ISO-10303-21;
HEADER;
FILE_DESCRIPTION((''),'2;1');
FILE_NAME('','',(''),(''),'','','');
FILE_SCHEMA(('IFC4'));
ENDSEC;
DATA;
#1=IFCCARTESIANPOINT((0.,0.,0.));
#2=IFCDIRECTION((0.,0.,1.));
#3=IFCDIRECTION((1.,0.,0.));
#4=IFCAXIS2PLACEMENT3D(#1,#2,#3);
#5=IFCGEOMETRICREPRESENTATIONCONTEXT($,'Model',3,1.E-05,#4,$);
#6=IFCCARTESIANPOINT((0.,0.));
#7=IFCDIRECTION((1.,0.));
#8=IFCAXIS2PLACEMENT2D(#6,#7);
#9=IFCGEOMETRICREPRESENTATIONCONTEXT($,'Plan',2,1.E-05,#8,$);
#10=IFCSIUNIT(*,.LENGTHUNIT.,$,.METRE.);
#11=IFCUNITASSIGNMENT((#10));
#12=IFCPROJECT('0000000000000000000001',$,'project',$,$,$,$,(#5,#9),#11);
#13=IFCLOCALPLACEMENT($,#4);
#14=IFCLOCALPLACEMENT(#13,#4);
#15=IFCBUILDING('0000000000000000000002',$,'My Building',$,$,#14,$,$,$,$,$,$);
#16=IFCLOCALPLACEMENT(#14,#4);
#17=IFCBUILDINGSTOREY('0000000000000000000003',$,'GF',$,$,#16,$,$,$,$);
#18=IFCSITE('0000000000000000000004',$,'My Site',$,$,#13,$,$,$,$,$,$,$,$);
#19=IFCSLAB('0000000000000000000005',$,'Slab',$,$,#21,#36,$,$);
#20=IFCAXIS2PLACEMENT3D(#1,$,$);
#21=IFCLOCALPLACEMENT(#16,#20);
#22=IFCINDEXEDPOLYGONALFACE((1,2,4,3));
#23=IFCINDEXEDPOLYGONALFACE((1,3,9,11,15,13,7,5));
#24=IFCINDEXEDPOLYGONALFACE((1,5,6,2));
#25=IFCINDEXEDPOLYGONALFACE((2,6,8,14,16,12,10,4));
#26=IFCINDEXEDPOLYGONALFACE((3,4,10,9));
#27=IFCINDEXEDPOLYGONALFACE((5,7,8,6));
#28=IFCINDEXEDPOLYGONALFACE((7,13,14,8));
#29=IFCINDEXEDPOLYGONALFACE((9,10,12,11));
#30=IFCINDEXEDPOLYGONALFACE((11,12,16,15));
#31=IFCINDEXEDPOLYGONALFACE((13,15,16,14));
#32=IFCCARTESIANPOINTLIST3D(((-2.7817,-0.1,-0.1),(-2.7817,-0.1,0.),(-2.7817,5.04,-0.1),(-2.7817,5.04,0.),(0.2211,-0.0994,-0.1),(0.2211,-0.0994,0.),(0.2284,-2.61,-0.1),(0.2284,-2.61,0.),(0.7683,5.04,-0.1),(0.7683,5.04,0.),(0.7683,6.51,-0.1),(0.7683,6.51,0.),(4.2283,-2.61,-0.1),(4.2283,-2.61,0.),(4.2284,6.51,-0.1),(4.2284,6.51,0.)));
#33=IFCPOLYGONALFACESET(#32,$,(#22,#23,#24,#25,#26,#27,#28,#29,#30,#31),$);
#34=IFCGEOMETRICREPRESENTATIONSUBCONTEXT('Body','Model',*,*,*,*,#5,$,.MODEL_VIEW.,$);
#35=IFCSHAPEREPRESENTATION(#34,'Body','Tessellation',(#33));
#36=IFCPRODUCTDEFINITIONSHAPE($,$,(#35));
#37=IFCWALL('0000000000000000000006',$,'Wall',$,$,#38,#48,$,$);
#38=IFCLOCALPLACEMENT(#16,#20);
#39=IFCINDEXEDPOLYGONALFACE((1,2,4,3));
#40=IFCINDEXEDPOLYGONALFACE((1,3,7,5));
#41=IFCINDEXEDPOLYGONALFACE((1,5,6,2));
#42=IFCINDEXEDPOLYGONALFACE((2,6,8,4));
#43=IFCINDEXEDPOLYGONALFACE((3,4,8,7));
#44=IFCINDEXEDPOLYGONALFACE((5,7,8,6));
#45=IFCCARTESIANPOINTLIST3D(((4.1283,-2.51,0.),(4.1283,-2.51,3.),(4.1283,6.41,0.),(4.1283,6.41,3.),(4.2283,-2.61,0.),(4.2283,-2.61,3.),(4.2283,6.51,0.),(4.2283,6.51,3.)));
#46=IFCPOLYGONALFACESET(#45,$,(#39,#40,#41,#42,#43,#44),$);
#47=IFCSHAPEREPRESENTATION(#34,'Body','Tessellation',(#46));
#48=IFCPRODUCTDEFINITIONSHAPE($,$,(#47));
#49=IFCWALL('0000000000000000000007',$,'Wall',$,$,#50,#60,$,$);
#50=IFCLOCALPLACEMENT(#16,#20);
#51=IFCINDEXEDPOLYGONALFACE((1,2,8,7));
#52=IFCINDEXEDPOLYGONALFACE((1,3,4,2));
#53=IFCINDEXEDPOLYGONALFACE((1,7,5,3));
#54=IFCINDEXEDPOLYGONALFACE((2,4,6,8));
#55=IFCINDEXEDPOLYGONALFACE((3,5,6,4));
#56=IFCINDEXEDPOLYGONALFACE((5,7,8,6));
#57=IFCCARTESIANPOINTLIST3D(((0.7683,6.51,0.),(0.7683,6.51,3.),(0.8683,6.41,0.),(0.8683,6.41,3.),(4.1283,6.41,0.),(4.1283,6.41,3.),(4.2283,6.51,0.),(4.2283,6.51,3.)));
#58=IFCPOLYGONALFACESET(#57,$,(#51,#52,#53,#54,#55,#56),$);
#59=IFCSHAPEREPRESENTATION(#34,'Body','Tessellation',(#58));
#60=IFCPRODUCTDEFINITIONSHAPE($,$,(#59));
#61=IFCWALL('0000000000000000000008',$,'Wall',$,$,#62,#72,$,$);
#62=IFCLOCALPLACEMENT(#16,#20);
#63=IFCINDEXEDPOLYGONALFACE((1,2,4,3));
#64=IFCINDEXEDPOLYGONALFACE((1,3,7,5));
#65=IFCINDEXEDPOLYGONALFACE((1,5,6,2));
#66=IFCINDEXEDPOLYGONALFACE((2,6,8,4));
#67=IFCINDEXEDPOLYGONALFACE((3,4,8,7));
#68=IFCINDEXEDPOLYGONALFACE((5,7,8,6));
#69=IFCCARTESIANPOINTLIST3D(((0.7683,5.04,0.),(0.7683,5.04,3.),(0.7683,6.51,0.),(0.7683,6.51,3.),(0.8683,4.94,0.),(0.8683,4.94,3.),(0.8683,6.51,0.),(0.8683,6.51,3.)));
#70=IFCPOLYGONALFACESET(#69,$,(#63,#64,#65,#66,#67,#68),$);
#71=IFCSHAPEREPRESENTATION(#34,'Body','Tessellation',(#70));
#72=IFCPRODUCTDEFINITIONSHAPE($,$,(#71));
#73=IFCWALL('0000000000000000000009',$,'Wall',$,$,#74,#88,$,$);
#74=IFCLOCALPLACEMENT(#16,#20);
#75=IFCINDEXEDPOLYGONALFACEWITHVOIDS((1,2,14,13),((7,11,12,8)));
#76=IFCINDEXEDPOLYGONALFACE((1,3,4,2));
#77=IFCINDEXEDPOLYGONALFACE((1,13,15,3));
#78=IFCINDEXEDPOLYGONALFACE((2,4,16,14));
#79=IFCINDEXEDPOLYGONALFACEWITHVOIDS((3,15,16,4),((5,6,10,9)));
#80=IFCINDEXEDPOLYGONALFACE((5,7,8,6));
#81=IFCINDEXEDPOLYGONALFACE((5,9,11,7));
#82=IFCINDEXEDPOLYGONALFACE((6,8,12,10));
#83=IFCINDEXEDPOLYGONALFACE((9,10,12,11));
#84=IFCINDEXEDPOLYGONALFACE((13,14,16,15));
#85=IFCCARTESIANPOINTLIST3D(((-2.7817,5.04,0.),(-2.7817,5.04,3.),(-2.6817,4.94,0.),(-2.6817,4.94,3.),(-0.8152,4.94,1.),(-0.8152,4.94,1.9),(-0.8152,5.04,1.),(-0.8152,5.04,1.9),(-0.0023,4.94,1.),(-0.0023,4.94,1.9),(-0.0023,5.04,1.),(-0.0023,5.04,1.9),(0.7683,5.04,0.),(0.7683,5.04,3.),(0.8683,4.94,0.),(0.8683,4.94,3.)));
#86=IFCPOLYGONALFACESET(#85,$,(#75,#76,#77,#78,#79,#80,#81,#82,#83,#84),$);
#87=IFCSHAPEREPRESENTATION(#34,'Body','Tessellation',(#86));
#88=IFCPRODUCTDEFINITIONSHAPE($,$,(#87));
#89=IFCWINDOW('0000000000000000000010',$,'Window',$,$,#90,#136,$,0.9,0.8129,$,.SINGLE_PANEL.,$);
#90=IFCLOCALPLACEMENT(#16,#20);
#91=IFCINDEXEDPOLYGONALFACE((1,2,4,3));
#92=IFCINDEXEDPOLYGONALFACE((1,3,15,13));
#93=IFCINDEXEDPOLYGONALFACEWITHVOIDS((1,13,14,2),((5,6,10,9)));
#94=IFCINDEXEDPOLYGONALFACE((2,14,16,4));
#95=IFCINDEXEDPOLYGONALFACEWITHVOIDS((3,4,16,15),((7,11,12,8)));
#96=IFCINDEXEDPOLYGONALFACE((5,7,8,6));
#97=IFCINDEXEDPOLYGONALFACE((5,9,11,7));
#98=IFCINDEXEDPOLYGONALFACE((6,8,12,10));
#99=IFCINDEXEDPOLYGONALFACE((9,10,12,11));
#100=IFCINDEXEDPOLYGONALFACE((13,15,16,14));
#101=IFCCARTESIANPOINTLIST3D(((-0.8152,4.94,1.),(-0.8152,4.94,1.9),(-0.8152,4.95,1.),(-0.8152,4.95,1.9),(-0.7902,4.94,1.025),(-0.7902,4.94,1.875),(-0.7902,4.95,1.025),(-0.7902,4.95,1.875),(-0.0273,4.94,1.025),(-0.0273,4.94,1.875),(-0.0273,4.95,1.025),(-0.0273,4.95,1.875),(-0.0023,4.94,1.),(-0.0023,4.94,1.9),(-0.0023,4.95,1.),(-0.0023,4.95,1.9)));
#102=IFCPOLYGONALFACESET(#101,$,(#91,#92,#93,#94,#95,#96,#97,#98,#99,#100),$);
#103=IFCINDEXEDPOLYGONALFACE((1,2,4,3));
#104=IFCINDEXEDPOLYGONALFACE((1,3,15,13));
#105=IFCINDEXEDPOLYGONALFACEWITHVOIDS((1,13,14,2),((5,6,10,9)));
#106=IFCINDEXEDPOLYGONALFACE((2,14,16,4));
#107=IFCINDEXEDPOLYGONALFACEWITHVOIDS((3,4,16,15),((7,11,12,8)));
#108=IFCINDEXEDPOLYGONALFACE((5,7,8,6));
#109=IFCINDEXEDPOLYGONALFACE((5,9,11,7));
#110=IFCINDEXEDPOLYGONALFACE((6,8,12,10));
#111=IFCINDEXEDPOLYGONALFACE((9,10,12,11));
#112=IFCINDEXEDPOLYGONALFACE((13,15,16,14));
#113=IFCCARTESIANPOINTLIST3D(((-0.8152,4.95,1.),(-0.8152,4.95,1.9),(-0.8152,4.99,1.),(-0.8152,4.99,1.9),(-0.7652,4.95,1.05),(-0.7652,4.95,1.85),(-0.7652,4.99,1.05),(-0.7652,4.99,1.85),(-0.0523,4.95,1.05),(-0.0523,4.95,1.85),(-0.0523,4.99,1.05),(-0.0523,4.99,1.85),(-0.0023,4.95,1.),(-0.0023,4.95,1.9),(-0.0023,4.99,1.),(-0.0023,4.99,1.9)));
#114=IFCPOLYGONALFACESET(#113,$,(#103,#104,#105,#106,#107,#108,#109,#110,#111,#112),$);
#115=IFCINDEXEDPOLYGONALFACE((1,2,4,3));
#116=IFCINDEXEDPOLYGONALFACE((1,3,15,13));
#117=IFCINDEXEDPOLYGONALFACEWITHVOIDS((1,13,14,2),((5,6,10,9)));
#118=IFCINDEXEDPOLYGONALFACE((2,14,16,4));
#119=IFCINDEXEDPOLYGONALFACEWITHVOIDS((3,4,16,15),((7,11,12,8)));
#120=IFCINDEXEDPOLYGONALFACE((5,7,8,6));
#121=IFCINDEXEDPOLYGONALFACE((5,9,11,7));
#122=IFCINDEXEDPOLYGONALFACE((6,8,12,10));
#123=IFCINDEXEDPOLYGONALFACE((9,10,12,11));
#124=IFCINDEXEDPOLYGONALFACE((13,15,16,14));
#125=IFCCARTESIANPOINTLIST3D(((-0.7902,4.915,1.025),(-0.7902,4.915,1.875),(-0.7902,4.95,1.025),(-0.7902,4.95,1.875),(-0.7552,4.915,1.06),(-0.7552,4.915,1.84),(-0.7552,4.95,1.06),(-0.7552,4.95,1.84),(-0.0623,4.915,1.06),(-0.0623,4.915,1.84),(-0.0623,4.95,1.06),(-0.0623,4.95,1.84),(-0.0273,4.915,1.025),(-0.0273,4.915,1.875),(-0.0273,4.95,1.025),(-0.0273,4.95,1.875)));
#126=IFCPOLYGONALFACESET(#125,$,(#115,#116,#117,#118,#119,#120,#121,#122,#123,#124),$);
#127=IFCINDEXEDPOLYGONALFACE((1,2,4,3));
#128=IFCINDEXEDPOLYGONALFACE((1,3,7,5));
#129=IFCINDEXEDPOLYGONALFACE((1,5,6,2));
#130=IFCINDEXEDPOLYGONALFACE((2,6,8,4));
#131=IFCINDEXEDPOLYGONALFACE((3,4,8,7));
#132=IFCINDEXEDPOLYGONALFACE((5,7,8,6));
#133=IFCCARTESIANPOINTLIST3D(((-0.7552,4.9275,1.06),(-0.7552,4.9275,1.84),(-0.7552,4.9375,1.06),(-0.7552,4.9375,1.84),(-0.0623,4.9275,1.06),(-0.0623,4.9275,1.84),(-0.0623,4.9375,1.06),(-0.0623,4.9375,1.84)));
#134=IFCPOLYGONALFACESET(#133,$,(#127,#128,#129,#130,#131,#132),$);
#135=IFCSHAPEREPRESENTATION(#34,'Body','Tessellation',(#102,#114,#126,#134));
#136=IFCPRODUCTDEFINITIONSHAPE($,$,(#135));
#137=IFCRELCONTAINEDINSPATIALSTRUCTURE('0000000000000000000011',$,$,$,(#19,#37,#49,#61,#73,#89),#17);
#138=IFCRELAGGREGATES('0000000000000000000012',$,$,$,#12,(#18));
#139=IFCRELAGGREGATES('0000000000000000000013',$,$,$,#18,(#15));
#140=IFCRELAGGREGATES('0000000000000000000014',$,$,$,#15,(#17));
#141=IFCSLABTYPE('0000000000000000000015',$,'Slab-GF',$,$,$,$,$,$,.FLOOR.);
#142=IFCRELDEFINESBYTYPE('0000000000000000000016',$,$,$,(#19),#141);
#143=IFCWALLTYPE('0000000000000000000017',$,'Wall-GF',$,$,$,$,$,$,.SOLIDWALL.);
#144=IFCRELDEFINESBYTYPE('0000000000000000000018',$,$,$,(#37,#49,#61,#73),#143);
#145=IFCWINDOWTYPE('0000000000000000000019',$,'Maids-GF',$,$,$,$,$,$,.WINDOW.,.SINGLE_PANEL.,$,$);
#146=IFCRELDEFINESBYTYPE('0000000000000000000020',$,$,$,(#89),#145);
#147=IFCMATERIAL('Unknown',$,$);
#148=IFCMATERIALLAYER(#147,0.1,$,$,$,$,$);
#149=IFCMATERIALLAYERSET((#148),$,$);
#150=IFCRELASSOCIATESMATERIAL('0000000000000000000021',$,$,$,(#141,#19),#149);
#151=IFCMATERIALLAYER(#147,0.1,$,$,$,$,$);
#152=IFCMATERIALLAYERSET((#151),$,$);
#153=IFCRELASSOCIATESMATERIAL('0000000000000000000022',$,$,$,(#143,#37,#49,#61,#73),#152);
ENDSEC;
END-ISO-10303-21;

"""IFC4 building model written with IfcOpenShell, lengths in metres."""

from ifc_helpers import new_model, entity, si_unit, frame, origin_with_axes, origin_2d_with_axis, place, context, subcontext, project, spatial, line, indexed_curve, outline, extrude, shape, source, transform, mapped, material, layer, layer_set, layer_usage, type_object, type_shapes, element, fill, save


model = new_model("IFC4")

# Units and contexts
model_context = context("Model", 3, precision=1e-05, world=origin_with_axes())
plan_context = context("Plan", 2, precision=1e-05, world=origin_2d_with_axis())
body_context_1 = subcontext(model_context, "Body", "Model", "MODEL_VIEW")
body_context_2 = subcontext(plan_context, "Body", "Plan", "PLAN_VIEW")
ifc_project = project(units=[si_unit("LENGTHUNIT", "METRE")], contexts=[model_context, plan_context])

# Site, building, storey
site_placement = place(None, origin_with_axes())
site = spatial("IfcSite", under=ifc_project, at=site_placement, Name="My Site")
building_placement = place(site_placement, origin_with_axes())
building = spatial("IfcBuilding", under=site, at=building_placement, Name="My Building")
storey_placement = place(building_placement, origin_with_axes())
storey = spatial("IfcBuildingStorey", under=building, at=storey_placement, Name="GF")

# Slab
ifc_material_1 = material(Name="Unknown")
ifc_layer_1 = layer(ifc_material_1, 0.1)
ifc_layer_set_1 = layer_set([ifc_layer_1])
ifc_layer_usage_1 = layer_usage(ifc_layer_set_1, "AXIS3", "POSITIVE", -0.1)
slab_type_1 = type_object("IfcSlabType", Name="Slab-GF", PredefinedType="FLOOR", material=ifc_layer_set_1)
slab_1_placement = place(storey_placement, frame((4.2283, -2.61, 0.0), z_axis=(0.0, 0.0, 1.0), x_axis=(1.0, 0.0, 0.0)))
element("IfcSlab", 1, at=slab_1_placement, inside=storey, type_object=slab_type_1, material=ifc_layer_usage_1, Name="Slab", context=body_context_1, shape_type="SweptSolid", body=[
    extrude(outline(indexed_curve([(0.0, 0.0), (0.0, 9.12), (-3.46, 9.12), (-3.46, 7.65), (-7.01, 7.65), (-7.01, 2.51), (-4.0073, 2.5106), (-4.0, 0.0), (0.0, 0.0)])), frame((0.0, 0.0, -0.1), z_axis=(0.0, 0.0, 1.0), x_axis=(1.0, 0.0, 0.0)), (0.0, 0.0, 1.0), 0.1),
])

# Shared definitions
ifc_layer_2 = layer(ifc_material_1, 0.1)
ifc_layer_set_2 = layer_set([ifc_layer_2])
wall_type = type_object("IfcWallType", Name="Wall-GF", PredefinedType="SOLIDWALL", material=ifc_layer_set_2)

# Walls
ifc_layer_usage_2 = layer_usage(ifc_layer_set_2, "AXIS2", "POSITIVE", 0.0)
wall_1_placement = place(storey_placement, frame((4.2283, -2.61, 0.0), z_axis=(0.0, 0.0, 1.0), x_axis=(0.0, 1.0, 0.0)))
element("IfcWall", 2, at=wall_1_placement, inside=storey, type_object=wall_type, material=ifc_layer_usage_2, Name="Wall", context=body_context_1, shape_type="SweptSolid", body=[
    extrude(outline(indexed_curve([(0.0, 0.0), (0.1, 0.1), (9.02, 0.1), (9.12, 0.0)], segments=[line(1, 2, 3, 4, 1)])), origin_with_axes(), (0.0, 0.0, 1.0), 3.0),
])
ifc_layer_usage_3 = layer_usage(ifc_layer_set_2, "AXIS2", "POSITIVE", 0.0)
wall_2_placement = place(storey_placement, frame((4.2283, 6.51, 0.0), z_axis=(0.0, 0.0, 1.0), x_axis=(-1.0, 0.0, 0.0)))
element("IfcWall", 3, at=wall_2_placement, inside=storey, type_object=wall_type, material=ifc_layer_usage_3, Name="Wall", context=body_context_1, shape_type="SweptSolid", body=[
    extrude(outline(indexed_curve([(0.0, 0.0), (0.1, 0.1), (3.36, 0.1), (3.46, 0.0)], segments=[line(1, 2, 3, 4, 1)])), origin_with_axes(), (0.0, 0.0, 1.0), 3.0),
])
ifc_layer_usage_4 = layer_usage(ifc_layer_set_2, "AXIS2", "POSITIVE", 0.0)
wall_3_placement = place(storey_placement, frame((0.7683, 6.51, 0.0), z_axis=(0.0, 0.0, 1.0), x_axis=(0.0, -1.0, 0.0)))
element("IfcWall", 4, at=wall_3_placement, inside=storey, type_object=wall_type, material=ifc_layer_usage_4, Name="Wall", context=body_context_1, shape_type="SweptSolid", body=[
    extrude(outline(indexed_curve([(0.0, 0.0), (0.0, 0.1), (1.57, 0.1), (1.47, 0.0)], segments=[line(1, 2, 3, 4, 1)])), origin_with_axes(), (0.0, 0.0, 1.0), 3.0),
])

# Wall, opening, window
ifc_layer_usage_5 = layer_usage(ifc_layer_set_2, "AXIS2", "POSITIVE", 0.0)
wall_4_placement = place(storey_placement, frame((0.7683, 5.04, 0.0), z_axis=(0.0, 0.0, 1.0), x_axis=(-1.0, 0.0, 0.0)))
wall_4 = element("IfcWall", 5, at=wall_4_placement, inside=storey, type_object=wall_type, material=ifc_layer_usage_5, Name="Wall", context=body_context_1, shape_type="SweptSolid", body=[
    extrude(outline(indexed_curve([(0.0, 0.0), (-0.1, 0.1), (3.45, 0.1), (3.55, 0.0)], segments=[line(1, 2, 3, 4, 1)])), origin_with_axes(), (0.0, 0.0, 1.0), 3.0),
])
shared_shape_1 = source(origin_with_axes(), body_context_1, "Body", "SweptSolid", [
    extrude(outline(indexed_curve([(0.0, 0.0), (0.8129, 0.0), (0.8129, 0.9), (0.0, 0.9)], segments=[line(1, 2, 3, 4, 1)])), frame((0.0, -0.6, 0.0), z_axis=(0.0, -1.0, 0.0), x_axis=(1.0, 0.0, 0.0)), (0.0, 0.0, -1.0), 1.2),
])
opening_1_placement = place(wall_4_placement, frame((0.7707, 0.0, 1.0), z_axis=(0.0, 0.0, 1.0), x_axis=(1.0, 0.0, 0.0)))
opening_1 = element("IfcOpeningElement", 6, at=opening_1_placement, cuts=wall_4, PredefinedType="OPENING", context=body_context_1, shape_type="MappedRepresentation", body=[
    mapped(shared_shape_1, transform((0.0, 0.0, 0.0), x_axis=(1.0, 0.0, 0.0), y_axis=(0.0, 1.0, 0.0), z_axis=(0.0, 0.0, 1.0), scale=1.0)),
])
window_type_1 = type_object("IfcWindowType", Name="Maids-GF", PartitioningType="SINGLE_PANEL", PredefinedType="WINDOW")
shared_shape_2 = source(origin_with_axes(), body_context_1, "Body", "SweptSolid", [
    extrude(outline(indexed_curve([(0.0, 0.0), (0.8129, 0.0), (0.8129, 0.9), (0.0, 0.9)], segments=[line(1, 2, 3, 4, 1)]), holes=[indexed_curve([(0.025, 0.025), (0.7879, 0.025), (0.7879, 0.875), (0.025, 0.875)], segments=[line(1, 2, 3, 4, 1)])]), frame((0.0, 0.09, 0.0), z_axis=(0.0, -1.0, 0.0), x_axis=(1.0, 0.0, 0.0)), (0.0, 0.0, -1.0), 0.01),
    extrude(outline(indexed_curve([(0.0, 0.0), (0.8129, 0.0), (0.8129, 0.9), (0.0, 0.9)], segments=[line(1, 2, 3, 4, 1)]), holes=[indexed_curve([(0.05, 0.05), (0.7629, 0.05), (0.7629, 0.85), (0.05, 0.85)], segments=[line(1, 2, 3, 4, 1)])]), frame((0.0, 0.05, 0.0), z_axis=(0.0, -1.0, 0.0), x_axis=(1.0, 0.0, 0.0)), (0.0, 0.0, -1.0), 0.04),
    extrude(outline(indexed_curve([(0.0, 0.0), (0.7629, 0.0), (0.7629, 0.85), (0.0, 0.85)], segments=[line(1, 2, 3, 4, 1)]), holes=[indexed_curve([(0.035, 0.035), (0.7279, 0.035), (0.7279, 0.815), (0.035, 0.815)], segments=[line(1, 2, 3, 4, 1)])]), frame((0.025, 0.09, 0.025), z_axis=(0.0, -1.0, 0.0), x_axis=(1.0, 0.0, 0.0)), (0.0, 0.0, -1.0), 0.035),
    extrude(outline(indexed_curve([(0.035, 0.035), (0.7279, 0.035), (0.7279, 0.815), (0.035, 0.815)], segments=[line(1, 2, 3, 4, 1)])), frame((0.025, 0.1025, 0.025), z_axis=(0.0, -1.0, 0.0), x_axis=(1.0, 0.0, 0.0)), (0.0, 0.0, -1.0), 0.01),
])
shared_shape_3 = source(origin_with_axes(), body_context_2, "Body", "Curve2D", [
    entity("IfcIndexedPolyCurve", entity("IfcCartesianPointList2D", [[0.05, 0.05], [0.7629, 0.05]])),
    entity("IfcIndexedPolyCurve", entity("IfcCartesianPointList2D", [[0.0, 0.1], [0.025, 0.1], [0.025, 0.09], [0.05, 0.09], [0.05, 0.05], [0.0, 0.05]]), [entity("IfcLineIndex", [1, 2, 3, 4, 5, 6, 1])]),
    entity("IfcIndexedPolyCurve", entity("IfcCartesianPointList2D", [[0.8129, 0.1], [0.7879, 0.1], [0.7879, 0.09], [0.7629, 0.09], [0.7629, 0.05], [0.8129, 0.05]]), [entity("IfcLineIndex", [1, 2, 3, 4, 5, 6, 1])]),
    entity("IfcIndexedPolyCurve", entity("IfcCartesianPointList2D", [[0.025, 0.09], [0.06, 0.09], [0.06, 0.125], [0.025, 0.125]]), [entity("IfcLineIndex", [1, 2, 3, 4, 1])]),
    entity("IfcIndexedPolyCurve", entity("IfcCartesianPointList2D", [[0.7879, 0.09], [0.7529, 0.09], [0.7529, 0.125], [0.7879, 0.125]]), [entity("IfcLineIndex", [1, 2, 3, 4, 1])]),
    entity("IfcIndexedPolyCurve", entity("IfcCartesianPointList2D", [[0.06, 0.09], [0.7529, 0.09]])),
    entity("IfcIndexedPolyCurve", entity("IfcCartesianPointList2D", [[0.06, 0.125], [0.7529, 0.125]])),
    entity("IfcIndexedPolyCurve", entity("IfcCartesianPointList2D", [[0.06, 0.1075], [0.7529, 0.1075]])),
])
type_shapes(window_type_1, [shared_shape_2, shared_shape_3])
window_1_placement = place(opening_1_placement, frame((0.0, 0.0, 0.0), z_axis=(0.0, 0.0, 1.0), x_axis=(1.0, 0.0, 0.0)))
window_1 = element("IfcWindow", 7, at=window_1_placement, inside=storey, type_object=window_type_1, Name="Window", OverallHeight=0.9, OverallWidth=0.8129, PartitioningType="SINGLE_PANEL", shapes=[
    shape(body_context_1, "Body", "MappedRepresentation", [mapped(shared_shape_2, transform((0.0, 0.0, 0.0), x_axis=(1.0, 0.0, 0.0), y_axis=(0.0, 1.0, 0.0), z_axis=(0.0, 0.0, 1.0), scale=1.0))]),
    shape(body_context_2, "Body", "MappedRepresentation", [mapped(shared_shape_3, transform((0.0, 0.0, 0.0), x_axis=(1.0, 0.0, 0.0), y_axis=(0.0, 1.0, 0.0), z_axis=(0.0, 0.0, 1.0), scale=1.0))]),
])
fill(opening_1, window_1)

save(model, "model.ifc")
